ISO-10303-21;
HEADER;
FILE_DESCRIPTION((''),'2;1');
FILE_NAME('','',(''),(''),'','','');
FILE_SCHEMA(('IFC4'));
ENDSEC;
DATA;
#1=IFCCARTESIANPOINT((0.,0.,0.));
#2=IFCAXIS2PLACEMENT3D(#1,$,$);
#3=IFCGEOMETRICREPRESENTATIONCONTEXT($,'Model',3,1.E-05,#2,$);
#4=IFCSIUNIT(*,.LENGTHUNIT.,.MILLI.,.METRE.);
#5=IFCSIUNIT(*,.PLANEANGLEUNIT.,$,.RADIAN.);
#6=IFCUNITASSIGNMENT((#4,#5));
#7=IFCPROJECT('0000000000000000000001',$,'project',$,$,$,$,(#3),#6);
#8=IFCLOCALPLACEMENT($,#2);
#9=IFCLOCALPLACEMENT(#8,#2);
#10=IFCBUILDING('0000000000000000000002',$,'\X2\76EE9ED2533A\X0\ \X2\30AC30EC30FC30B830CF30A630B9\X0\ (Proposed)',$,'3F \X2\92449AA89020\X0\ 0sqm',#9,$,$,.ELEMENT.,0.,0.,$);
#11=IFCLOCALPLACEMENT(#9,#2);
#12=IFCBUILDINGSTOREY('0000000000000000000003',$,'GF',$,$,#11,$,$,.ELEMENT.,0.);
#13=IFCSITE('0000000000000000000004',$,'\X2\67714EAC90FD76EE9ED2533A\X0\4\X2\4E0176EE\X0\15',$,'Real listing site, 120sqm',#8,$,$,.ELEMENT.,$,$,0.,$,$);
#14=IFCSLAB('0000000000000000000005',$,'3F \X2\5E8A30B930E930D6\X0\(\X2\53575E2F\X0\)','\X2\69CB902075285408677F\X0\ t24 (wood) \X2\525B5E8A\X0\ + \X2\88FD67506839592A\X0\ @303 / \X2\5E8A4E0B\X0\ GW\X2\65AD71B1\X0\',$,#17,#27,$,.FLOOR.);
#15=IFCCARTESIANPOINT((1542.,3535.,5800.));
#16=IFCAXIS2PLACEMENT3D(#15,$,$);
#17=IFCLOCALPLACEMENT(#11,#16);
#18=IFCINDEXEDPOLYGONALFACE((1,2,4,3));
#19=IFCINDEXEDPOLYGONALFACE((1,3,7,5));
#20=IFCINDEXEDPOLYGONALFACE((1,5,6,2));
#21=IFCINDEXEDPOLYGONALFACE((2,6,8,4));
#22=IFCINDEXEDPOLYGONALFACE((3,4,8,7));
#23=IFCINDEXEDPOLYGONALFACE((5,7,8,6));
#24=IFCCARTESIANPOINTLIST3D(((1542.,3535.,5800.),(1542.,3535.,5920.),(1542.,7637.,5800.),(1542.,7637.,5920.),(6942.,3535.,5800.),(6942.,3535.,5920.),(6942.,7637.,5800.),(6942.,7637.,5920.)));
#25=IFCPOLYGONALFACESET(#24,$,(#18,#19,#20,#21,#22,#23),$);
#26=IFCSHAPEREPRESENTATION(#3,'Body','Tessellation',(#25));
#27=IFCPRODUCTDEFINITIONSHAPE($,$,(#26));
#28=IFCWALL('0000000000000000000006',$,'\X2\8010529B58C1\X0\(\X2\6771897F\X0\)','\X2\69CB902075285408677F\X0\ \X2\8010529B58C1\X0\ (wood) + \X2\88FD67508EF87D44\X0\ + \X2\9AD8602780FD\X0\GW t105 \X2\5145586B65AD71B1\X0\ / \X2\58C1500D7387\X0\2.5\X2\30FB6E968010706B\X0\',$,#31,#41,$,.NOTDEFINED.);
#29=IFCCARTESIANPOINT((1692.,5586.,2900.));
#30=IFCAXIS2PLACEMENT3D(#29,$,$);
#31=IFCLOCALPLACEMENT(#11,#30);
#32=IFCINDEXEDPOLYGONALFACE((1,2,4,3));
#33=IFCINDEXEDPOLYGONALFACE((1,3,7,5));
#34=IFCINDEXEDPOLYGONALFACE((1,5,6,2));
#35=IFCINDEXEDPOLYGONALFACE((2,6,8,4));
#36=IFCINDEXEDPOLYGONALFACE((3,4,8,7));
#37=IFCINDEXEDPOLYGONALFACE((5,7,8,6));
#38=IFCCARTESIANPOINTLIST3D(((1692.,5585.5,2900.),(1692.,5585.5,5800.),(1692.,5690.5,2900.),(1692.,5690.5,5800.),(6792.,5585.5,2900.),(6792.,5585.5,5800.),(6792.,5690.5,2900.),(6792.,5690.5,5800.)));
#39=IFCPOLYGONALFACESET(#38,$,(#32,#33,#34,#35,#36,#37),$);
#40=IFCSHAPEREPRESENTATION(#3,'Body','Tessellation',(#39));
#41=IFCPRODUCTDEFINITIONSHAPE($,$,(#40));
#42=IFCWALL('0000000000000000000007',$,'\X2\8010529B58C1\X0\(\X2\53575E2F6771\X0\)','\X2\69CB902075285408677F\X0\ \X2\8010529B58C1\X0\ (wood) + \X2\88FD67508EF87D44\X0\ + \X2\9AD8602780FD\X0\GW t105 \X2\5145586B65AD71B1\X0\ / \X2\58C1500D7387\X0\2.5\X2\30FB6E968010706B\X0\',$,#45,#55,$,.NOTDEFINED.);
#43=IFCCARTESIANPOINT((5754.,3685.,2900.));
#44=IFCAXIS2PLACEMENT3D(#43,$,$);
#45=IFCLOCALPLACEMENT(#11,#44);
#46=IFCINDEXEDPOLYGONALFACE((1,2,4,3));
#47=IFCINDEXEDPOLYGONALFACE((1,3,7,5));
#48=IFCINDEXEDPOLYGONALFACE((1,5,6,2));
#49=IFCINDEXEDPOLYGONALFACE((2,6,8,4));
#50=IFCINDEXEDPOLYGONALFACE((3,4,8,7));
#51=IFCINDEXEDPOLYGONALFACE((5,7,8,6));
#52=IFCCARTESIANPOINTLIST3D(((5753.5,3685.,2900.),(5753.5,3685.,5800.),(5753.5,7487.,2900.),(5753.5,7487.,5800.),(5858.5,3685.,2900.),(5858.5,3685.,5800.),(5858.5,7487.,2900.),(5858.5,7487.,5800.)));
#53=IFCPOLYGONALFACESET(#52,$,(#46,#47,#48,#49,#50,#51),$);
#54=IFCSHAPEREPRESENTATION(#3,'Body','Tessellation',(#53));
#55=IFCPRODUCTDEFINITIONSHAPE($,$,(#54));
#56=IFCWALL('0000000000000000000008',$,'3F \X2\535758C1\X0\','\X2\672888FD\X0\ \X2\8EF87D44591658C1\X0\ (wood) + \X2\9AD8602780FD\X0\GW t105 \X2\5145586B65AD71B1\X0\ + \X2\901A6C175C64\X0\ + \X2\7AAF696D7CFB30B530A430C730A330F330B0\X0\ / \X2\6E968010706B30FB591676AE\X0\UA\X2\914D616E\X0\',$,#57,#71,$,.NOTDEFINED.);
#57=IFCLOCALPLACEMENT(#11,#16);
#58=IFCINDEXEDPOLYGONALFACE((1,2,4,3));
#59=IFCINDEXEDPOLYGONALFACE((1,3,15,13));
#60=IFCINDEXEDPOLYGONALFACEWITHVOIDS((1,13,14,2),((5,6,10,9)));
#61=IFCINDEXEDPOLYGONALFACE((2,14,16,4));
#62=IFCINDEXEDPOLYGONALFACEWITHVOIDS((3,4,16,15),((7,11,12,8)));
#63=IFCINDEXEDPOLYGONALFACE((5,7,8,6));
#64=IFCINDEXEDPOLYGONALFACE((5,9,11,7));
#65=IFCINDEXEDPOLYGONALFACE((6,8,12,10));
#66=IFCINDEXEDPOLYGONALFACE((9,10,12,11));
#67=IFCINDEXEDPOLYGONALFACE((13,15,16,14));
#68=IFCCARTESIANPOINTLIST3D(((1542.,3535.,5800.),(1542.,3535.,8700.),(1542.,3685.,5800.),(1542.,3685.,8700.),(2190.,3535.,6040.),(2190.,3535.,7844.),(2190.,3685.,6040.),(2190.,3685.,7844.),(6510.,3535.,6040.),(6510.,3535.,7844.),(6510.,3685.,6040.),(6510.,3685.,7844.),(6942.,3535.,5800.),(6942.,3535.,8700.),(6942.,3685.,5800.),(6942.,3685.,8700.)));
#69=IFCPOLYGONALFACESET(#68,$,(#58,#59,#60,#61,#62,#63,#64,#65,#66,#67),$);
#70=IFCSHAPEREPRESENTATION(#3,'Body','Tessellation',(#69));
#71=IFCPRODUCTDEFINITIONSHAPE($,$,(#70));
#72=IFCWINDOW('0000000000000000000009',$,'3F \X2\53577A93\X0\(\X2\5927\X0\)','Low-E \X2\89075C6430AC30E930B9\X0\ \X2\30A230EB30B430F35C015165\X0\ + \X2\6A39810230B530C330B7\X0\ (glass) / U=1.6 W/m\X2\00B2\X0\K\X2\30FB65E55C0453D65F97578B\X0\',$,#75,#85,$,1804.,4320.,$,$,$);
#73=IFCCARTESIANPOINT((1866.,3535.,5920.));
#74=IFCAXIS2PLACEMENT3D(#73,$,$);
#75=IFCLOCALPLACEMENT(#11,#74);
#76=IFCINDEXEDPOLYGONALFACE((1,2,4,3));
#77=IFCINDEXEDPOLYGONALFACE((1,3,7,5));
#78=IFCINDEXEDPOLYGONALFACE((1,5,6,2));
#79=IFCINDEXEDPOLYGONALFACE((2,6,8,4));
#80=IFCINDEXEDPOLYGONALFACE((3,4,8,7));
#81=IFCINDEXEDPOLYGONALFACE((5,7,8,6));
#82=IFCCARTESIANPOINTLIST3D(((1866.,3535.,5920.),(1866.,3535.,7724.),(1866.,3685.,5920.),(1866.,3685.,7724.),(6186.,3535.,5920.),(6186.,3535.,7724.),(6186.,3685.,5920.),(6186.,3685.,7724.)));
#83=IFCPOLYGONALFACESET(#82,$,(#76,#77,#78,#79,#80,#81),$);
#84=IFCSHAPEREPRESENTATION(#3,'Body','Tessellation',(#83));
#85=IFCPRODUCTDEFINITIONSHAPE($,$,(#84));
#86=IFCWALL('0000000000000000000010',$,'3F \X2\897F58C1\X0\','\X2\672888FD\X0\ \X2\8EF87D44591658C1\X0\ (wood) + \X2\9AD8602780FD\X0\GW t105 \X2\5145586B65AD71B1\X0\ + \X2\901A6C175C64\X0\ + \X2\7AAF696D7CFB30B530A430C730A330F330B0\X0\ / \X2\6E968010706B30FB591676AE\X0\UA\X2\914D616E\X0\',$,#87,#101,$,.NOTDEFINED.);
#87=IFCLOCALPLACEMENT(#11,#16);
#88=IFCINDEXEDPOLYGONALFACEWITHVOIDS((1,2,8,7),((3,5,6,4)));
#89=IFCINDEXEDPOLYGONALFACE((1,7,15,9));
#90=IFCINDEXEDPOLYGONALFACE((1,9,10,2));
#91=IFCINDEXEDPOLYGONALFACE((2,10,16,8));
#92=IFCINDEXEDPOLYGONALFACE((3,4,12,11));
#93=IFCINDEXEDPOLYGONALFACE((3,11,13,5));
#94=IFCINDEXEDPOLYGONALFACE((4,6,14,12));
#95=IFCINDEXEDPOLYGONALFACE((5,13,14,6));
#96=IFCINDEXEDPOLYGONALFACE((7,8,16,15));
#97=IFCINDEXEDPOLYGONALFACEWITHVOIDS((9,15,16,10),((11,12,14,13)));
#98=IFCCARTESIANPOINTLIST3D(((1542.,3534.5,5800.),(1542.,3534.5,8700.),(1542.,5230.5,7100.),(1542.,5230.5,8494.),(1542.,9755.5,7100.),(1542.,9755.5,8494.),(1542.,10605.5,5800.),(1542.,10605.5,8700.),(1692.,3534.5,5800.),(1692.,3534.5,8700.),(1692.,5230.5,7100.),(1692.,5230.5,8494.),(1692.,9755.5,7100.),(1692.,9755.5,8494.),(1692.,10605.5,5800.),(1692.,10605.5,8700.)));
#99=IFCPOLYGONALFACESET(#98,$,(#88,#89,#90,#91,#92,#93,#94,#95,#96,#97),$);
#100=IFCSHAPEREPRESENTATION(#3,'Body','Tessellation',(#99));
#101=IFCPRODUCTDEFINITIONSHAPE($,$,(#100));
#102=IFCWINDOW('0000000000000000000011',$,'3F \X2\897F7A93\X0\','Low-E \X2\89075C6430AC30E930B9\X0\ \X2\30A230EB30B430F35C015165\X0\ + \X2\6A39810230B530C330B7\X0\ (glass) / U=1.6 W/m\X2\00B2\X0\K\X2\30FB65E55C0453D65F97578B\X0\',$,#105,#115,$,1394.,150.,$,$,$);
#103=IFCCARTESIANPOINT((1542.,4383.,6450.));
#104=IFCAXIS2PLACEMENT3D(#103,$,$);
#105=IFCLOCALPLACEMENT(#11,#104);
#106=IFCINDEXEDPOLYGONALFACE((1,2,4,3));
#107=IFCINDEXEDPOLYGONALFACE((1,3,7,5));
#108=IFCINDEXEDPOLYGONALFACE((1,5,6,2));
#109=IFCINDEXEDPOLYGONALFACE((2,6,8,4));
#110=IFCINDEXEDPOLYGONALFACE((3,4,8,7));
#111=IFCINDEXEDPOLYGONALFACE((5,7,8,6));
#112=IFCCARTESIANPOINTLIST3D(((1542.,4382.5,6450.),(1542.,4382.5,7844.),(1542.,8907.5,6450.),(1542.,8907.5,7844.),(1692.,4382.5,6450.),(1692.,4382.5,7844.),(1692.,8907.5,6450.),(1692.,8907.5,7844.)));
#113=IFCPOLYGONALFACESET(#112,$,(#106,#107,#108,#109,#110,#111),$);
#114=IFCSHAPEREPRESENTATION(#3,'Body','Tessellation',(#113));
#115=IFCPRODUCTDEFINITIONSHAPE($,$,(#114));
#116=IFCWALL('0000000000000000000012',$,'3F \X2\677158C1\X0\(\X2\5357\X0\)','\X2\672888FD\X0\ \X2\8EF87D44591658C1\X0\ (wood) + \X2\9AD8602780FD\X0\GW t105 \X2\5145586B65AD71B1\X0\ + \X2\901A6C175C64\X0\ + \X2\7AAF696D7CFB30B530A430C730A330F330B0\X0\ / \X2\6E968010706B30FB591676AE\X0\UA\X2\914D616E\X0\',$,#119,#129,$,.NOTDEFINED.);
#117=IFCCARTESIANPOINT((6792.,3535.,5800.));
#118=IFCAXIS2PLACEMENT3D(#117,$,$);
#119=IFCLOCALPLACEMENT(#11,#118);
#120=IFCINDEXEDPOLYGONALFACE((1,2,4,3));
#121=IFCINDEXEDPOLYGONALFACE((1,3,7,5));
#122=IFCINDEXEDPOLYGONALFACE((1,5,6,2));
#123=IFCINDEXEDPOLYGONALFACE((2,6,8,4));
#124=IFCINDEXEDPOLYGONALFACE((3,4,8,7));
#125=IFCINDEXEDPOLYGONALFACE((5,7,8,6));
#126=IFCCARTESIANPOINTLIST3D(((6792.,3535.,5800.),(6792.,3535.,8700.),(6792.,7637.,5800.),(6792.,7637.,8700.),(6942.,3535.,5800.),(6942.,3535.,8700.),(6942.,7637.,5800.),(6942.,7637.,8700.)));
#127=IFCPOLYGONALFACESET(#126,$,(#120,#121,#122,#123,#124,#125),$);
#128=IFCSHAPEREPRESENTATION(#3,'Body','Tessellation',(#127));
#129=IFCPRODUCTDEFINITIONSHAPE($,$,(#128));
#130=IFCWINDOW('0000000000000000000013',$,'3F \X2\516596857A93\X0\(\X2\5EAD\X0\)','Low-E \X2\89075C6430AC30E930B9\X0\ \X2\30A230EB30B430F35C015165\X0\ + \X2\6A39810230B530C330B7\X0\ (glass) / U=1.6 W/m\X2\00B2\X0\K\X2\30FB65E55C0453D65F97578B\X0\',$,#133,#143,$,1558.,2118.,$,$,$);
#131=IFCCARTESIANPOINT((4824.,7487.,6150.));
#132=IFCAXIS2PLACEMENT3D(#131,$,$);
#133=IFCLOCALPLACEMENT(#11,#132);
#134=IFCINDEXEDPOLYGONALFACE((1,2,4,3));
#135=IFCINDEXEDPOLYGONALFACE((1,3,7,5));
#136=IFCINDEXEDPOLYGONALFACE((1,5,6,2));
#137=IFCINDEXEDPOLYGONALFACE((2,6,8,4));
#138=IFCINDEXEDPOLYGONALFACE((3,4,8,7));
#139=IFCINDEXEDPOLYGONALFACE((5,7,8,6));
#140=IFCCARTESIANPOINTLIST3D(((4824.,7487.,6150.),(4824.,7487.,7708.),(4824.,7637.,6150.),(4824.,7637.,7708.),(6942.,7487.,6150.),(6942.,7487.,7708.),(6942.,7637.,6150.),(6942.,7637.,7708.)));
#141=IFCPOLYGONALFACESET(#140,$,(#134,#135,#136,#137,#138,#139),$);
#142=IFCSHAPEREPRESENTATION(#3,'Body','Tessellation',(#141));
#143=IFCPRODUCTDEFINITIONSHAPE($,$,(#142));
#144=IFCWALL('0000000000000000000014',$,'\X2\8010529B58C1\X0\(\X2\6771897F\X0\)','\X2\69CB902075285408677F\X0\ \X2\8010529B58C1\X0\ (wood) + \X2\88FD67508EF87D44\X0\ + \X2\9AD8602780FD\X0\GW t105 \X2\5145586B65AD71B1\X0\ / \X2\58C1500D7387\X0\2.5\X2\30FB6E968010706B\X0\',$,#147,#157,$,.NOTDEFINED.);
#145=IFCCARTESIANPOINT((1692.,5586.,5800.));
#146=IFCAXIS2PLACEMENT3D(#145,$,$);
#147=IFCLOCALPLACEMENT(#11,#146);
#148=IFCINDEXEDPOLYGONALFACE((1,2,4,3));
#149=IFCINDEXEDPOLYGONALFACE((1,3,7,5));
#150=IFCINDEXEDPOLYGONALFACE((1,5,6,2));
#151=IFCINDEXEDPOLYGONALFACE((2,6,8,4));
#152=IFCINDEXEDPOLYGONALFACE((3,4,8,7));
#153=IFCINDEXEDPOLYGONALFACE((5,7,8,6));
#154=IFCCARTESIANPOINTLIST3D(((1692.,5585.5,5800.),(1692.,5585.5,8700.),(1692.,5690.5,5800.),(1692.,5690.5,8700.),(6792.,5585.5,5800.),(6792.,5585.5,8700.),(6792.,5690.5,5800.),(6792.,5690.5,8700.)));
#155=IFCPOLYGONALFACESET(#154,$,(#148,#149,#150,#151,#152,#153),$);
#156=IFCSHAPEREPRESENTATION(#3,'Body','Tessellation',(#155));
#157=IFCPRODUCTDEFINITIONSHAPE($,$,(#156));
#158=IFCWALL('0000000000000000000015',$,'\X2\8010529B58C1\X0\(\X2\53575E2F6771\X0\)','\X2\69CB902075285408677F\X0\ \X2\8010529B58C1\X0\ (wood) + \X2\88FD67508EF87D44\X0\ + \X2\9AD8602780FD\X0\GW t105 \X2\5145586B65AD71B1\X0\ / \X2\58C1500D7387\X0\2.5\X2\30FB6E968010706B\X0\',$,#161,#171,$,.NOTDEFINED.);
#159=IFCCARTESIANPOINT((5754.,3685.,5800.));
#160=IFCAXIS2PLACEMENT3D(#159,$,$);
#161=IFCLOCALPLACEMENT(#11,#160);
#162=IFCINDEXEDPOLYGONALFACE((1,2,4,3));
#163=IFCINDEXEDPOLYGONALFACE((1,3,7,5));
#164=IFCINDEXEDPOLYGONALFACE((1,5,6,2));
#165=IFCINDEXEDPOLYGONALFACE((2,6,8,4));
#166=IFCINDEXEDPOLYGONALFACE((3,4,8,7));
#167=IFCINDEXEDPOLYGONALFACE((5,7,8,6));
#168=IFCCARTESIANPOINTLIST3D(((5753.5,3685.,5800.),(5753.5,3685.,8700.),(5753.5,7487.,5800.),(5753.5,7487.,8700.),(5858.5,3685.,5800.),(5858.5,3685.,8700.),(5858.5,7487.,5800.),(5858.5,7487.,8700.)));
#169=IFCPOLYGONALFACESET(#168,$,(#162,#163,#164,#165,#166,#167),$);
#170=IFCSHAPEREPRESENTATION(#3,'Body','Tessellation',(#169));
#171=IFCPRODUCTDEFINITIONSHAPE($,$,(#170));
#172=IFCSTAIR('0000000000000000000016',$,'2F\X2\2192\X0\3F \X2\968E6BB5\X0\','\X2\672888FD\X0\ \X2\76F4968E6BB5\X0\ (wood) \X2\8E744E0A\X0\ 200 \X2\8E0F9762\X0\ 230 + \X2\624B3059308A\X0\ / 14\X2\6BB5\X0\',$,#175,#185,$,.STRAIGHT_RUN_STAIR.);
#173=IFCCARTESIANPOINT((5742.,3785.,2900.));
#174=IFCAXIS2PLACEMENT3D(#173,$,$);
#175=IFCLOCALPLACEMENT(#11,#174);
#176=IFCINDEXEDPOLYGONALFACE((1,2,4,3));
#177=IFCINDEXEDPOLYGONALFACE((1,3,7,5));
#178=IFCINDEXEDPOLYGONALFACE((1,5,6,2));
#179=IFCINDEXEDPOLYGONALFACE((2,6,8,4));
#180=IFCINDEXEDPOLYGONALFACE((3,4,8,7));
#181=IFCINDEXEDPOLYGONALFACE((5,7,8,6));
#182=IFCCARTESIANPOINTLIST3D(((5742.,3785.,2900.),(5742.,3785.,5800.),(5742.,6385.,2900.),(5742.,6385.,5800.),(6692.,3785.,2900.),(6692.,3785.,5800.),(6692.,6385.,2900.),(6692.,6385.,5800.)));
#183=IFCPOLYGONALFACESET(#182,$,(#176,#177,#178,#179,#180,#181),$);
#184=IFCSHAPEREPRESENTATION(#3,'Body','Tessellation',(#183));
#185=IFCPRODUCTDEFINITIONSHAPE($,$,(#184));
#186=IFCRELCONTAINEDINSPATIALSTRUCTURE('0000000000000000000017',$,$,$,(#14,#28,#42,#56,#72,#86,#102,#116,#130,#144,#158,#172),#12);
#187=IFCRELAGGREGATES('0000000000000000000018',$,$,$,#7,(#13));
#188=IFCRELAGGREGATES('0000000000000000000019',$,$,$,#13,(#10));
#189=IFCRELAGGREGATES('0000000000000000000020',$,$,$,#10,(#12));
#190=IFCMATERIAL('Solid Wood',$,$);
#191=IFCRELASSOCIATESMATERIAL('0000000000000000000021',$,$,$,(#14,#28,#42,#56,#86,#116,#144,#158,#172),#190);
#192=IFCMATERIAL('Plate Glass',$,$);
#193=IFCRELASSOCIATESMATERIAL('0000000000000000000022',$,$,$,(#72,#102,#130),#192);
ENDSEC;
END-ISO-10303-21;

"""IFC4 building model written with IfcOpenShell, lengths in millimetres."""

from ifc_helpers import new_model, si_unit, frame, frame_2d, origin, place, context, project, spatial, rectangle, extrude, material, element, fill, save


model = new_model("IFC4")

# Units and contexts
model_context = context("Model", 3, precision=1e-05, world=origin())
ifc_project = project(units=[si_unit("LENGTHUNIT", "METRE", prefix="MILLI"), si_unit("PLANEANGLEUNIT", "RADIAN")], contexts=[model_context])

# Site, building, storey
site_placement = place(None, origin())
site = spatial("IfcSite", under=ifc_project, at=site_placement, Name="東京都目黒区4丁目15", ObjectType="Real listing site, 120sqm", CompositionType="ELEMENT", RefElevation=0.0)
building_placement = place(site_placement, origin())
building = spatial("IfcBuilding", under=site, at=building_placement, Name="目黒区 ガレージハウス (Proposed)", ObjectType="3F 鉄骨造 0sqm", CompositionType="ELEMENT", ElevationOfRefHeight=0.0, ElevationOfTerrain=0.0)
storey_placement = place(building_placement, origin())
storey = spatial("IfcBuildingStorey", under=building, at=storey_placement, Name="GF", CompositionType="ELEMENT", Elevation=0.0)

# Slab
ifc_material_1 = material(Name="Solid Wood")
slab_placement = place(storey_placement, frame((1542.0, 3535.0, 5800.0)))
element("IfcSlab", 1, at=slab_placement, inside=storey, material=ifc_material_1, Name="3F 床スラブ(南帯)", Description="構造用合板 t24 (wood) 剛床 + 製材根太 @303 / 床下 GW断熱", PredefinedType="FLOOR", context=model_context, shape_type="SweptSolid", body=[
    extrude(rectangle(XDim=5400.0, YDim=4102.0, at=frame_2d((2700.0, 2051.0))), frame((1542.0, 3535.0, 5800.0)), (0.0, 0.0, 1.0), 120.0),
])

# Wall
wall_1_placement = place(storey_placement, frame((1692.0, 5586.0, 2900.0)))
element("IfcWall", 2, at=wall_1_placement, inside=storey, material=ifc_material_1, Name="耐力壁(東西)", Description="構造用合板 耐力壁 (wood) + 製材軸組 + 高性能GW t105 充填断熱 / 壁倍率2.5・準耐火", PredefinedType="NOTDEFINED", context=model_context, shape_type="SweptSolid", body=[
    extrude(rectangle(XDim=5100.0, YDim=105.0, at=frame_2d((2550.0, 52.0))), frame((1692.0, 5586.0, 2900.0)), (0.0, 0.0, 1.0), 2900.0),
])

# Wall
wall_2_placement = place(storey_placement, frame((5754.0, 3685.0, 2900.0)))
element("IfcWall", 3, at=wall_2_placement, inside=storey, material=ifc_material_1, Name="耐力壁(南帯東)", Description="構造用合板 耐力壁 (wood) + 製材軸組 + 高性能GW t105 充填断熱 / 壁倍率2.5・準耐火", PredefinedType="NOTDEFINED", context=model_context, shape_type="SweptSolid", body=[
    extrude(rectangle(XDim=105.0, YDim=3802.0, at=frame_2d((52.0, 1901.0))), frame((5754.0, 3685.0, 2900.0)), (0.0, 0.0, 1.0), 2900.0),
])

# Walls, openings, windows
wall_3_placement = place(storey_placement, frame((1542.0, 3535.0, 5800.0)))
wall_3 = element("IfcWall", 4, at=wall_3_placement, inside=storey, material=ifc_material_1, Name="3F 南壁", Description="木製 軸組外壁 (wood) + 高性能GW t105 充填断熱 + 通気層 + 窯業系サイディング / 準耐火・外皮UA配慮", PredefinedType="NOTDEFINED", context=model_context, shape_type="SweptSolid", body=[
    extrude(rectangle(XDim=5400.0, YDim=150.0, at=frame_2d((2700.0, 75.0))), frame((1542.0, 3535.0, 5800.0)), (0.0, 0.0, 1.0), 2900.0),
])
opening_1_placement = place(storey_placement, frame((1866.0, 3535.0, 5920.0)))
opening_1 = element("IfcOpeningElement", 5, at=opening_1_placement, cuts=wall_3, PredefinedType="NOTDEFINED", context=model_context, shape_type="SweptSolid", body=[
    extrude(rectangle(XDim=4320.0, YDim=150.0, at=frame_2d((2160.0, 75.0))), frame((1866.0, 3535.0, 5920.0)), (0.0, 0.0, 1.0), 1804.0),
])
ifc_material_2 = material(Name="Plate Glass")
window_1_placement = place(storey_placement, frame((1866.0, 3535.0, 5920.0)))
window_1 = element("IfcWindow", 6, at=window_1_placement, inside=storey, material=ifc_material_2, Name="3F 南窓(大)", Description="Low-E 複層ガラス アルゴン封入 + 樹脂サッシ (glass) / U=1.6 W/m²K・日射取得型", OverallHeight=1804.0, OverallWidth=4320.0, context=model_context, shape_type="SweptSolid", body=[
    extrude(rectangle(XDim=4320.0, YDim=150.0, at=frame_2d((2160.0, 75.0))), frame((1866.0, 3535.0, 5920.0)), (0.0, 0.0, 1.0), 1804.0),
])
fill(opening_1, window_1)
wall_4_placement = place(storey_placement, frame((1542.0, 3535.0, 5800.0)))
wall_4 = element("IfcWall", 7, at=wall_4_placement, inside=storey, material=ifc_material_1, Name="3F 西壁", Description="木製 軸組外壁 (wood) + 高性能GW t105 充填断熱 + 通気層 + 窯業系サイディング / 準耐火・外皮UA配慮", PredefinedType="NOTDEFINED", context=model_context, shape_type="SweptSolid", body=[
    extrude(rectangle(XDim=150.0, YDim=7071.0, at=frame_2d((75.0, 3535.0))), frame((1542.0, 3535.0, 5800.0)), (0.0, 0.0, 1.0), 2900.0),
])
opening_2_placement = place(storey_placement, frame((1542.0, 4383.0, 6450.0)))
opening_2 = element("IfcOpeningElement", 8, at=opening_2_placement, cuts=wall_4, PredefinedType="NOTDEFINED", context=model_context, shape_type="SweptSolid", body=[
    extrude(rectangle(XDim=150.0, YDim=4525.0, at=frame_2d((75.0, 2262.0))), frame((1542.0, 4383.0, 6450.0)), (0.0, 0.0, 1.0), 1394.0),
])
window_2_placement = place(storey_placement, frame((1542.0, 4383.0, 6450.0)))
window_2 = element("IfcWindow", 9, at=window_2_placement, inside=storey, material=ifc_material_2, Name="3F 西窓", Description="Low-E 複層ガラス アルゴン封入 + 樹脂サッシ (glass) / U=1.6 W/m²K・日射取得型", OverallHeight=1394.0, OverallWidth=150.0, context=model_context, shape_type="SweptSolid", body=[
    extrude(rectangle(XDim=150.0, YDim=4525.0, at=frame_2d((75.0, 2262.0))), frame((1542.0, 4383.0, 6450.0)), (0.0, 0.0, 1.0), 1394.0),
])
fill(opening_2, window_2)
wall_5_placement = place(storey_placement, frame((6792.0, 3535.0, 5800.0)))
wall_5 = element("IfcWall", 10, at=wall_5_placement, inside=storey, material=ifc_material_1, Name="3F 東壁(南)", Description="木製 軸組外壁 (wood) + 高性能GW t105 充填断熱 + 通気層 + 窯業系サイディング / 準耐火・外皮UA配慮", PredefinedType="NOTDEFINED", context=model_context, shape_type="SweptSolid", body=[
    extrude(rectangle(XDim=150.0, YDim=4102.0, at=frame_2d((75.0, 2051.0))), frame((6792.0, 3535.0, 5800.0)), (0.0, 0.0, 1.0), 2900.0),
])
opening_3_placement = place(storey_placement, frame((4824.0, 7487.0, 6150.0)))
opening_3 = element("IfcOpeningElement", 11, at=opening_3_placement, cuts=wall_5, PredefinedType="NOTDEFINED", context=model_context, shape_type="SweptSolid", body=[
    extrude(rectangle(XDim=2118.0, YDim=150.0, at=frame_2d((1059.0, 75.0))), frame((4824.0, 7487.0, 6150.0)), (0.0, 0.0, 1.0), 1558.0),
])
window_3_placement = place(storey_placement, frame((4824.0, 7487.0, 6150.0)))
window_3 = element("IfcWindow", 12, at=window_3_placement, inside=storey, material=ifc_material_2, Name="3F 入隅窓(庭)", Description="Low-E 複層ガラス アルゴン封入 + 樹脂サッシ (glass) / U=1.6 W/m²K・日射取得型", OverallHeight=1558.0, OverallWidth=2118.0, context=model_context, shape_type="SweptSolid", body=[
    extrude(rectangle(XDim=2118.0, YDim=150.0, at=frame_2d((1059.0, 75.0))), frame((4824.0, 7487.0, 6150.0)), (0.0, 0.0, 1.0), 1558.0),
])
fill(opening_3, window_3)

# Wall
wall_6_placement = place(storey_placement, frame((1692.0, 5586.0, 5800.0)))
element("IfcWall", 13, at=wall_6_placement, inside=storey, material=ifc_material_1, Name="耐力壁(東西)", Description="構造用合板 耐力壁 (wood) + 製材軸組 + 高性能GW t105 充填断熱 / 壁倍率2.5・準耐火", PredefinedType="NOTDEFINED", context=model_context, shape_type="SweptSolid", body=[
    extrude(rectangle(XDim=5100.0, YDim=105.0, at=frame_2d((2550.0, 52.0))), frame((1692.0, 5586.0, 5800.0)), (0.0, 0.0, 1.0), 2900.0),
])

# Wall
wall_7_placement = place(storey_placement, frame((5754.0, 3685.0, 5800.0)))
element("IfcWall", 14, at=wall_7_placement, inside=storey, material=ifc_material_1, Name="耐力壁(南帯東)", Description="構造用合板 耐力壁 (wood) + 製材軸組 + 高性能GW t105 充填断熱 / 壁倍率2.5・準耐火", PredefinedType="NOTDEFINED", context=model_context, shape_type="SweptSolid", body=[
    extrude(rectangle(XDim=105.0, YDim=3802.0, at=frame_2d((52.0, 1901.0))), frame((5754.0, 3685.0, 5800.0)), (0.0, 0.0, 1.0), 2900.0),
])

# Stair
stair_placement = place(storey_placement, frame((5742.0, 3785.0, 2900.0)))
element("IfcStair", 15, at=stair_placement, inside=storey, material=ifc_material_1, Name="2F→3F 階段", Description="木製 直階段 (wood) 蹴上 200 踏面 230 + 手すり / 14段", PredefinedType="STRAIGHT_RUN_STAIR", context=model_context, shape_type="SweptSolid", body=[
    extrude(rectangle(XDim=950.0, YDim=2600.0, at=frame_2d((475.0, 1300.0))), frame((5742.0, 3785.0, 2900.0)), (0.0, 0.0, 1.0), 2900.0),
])

save(model, "model.ifc")
